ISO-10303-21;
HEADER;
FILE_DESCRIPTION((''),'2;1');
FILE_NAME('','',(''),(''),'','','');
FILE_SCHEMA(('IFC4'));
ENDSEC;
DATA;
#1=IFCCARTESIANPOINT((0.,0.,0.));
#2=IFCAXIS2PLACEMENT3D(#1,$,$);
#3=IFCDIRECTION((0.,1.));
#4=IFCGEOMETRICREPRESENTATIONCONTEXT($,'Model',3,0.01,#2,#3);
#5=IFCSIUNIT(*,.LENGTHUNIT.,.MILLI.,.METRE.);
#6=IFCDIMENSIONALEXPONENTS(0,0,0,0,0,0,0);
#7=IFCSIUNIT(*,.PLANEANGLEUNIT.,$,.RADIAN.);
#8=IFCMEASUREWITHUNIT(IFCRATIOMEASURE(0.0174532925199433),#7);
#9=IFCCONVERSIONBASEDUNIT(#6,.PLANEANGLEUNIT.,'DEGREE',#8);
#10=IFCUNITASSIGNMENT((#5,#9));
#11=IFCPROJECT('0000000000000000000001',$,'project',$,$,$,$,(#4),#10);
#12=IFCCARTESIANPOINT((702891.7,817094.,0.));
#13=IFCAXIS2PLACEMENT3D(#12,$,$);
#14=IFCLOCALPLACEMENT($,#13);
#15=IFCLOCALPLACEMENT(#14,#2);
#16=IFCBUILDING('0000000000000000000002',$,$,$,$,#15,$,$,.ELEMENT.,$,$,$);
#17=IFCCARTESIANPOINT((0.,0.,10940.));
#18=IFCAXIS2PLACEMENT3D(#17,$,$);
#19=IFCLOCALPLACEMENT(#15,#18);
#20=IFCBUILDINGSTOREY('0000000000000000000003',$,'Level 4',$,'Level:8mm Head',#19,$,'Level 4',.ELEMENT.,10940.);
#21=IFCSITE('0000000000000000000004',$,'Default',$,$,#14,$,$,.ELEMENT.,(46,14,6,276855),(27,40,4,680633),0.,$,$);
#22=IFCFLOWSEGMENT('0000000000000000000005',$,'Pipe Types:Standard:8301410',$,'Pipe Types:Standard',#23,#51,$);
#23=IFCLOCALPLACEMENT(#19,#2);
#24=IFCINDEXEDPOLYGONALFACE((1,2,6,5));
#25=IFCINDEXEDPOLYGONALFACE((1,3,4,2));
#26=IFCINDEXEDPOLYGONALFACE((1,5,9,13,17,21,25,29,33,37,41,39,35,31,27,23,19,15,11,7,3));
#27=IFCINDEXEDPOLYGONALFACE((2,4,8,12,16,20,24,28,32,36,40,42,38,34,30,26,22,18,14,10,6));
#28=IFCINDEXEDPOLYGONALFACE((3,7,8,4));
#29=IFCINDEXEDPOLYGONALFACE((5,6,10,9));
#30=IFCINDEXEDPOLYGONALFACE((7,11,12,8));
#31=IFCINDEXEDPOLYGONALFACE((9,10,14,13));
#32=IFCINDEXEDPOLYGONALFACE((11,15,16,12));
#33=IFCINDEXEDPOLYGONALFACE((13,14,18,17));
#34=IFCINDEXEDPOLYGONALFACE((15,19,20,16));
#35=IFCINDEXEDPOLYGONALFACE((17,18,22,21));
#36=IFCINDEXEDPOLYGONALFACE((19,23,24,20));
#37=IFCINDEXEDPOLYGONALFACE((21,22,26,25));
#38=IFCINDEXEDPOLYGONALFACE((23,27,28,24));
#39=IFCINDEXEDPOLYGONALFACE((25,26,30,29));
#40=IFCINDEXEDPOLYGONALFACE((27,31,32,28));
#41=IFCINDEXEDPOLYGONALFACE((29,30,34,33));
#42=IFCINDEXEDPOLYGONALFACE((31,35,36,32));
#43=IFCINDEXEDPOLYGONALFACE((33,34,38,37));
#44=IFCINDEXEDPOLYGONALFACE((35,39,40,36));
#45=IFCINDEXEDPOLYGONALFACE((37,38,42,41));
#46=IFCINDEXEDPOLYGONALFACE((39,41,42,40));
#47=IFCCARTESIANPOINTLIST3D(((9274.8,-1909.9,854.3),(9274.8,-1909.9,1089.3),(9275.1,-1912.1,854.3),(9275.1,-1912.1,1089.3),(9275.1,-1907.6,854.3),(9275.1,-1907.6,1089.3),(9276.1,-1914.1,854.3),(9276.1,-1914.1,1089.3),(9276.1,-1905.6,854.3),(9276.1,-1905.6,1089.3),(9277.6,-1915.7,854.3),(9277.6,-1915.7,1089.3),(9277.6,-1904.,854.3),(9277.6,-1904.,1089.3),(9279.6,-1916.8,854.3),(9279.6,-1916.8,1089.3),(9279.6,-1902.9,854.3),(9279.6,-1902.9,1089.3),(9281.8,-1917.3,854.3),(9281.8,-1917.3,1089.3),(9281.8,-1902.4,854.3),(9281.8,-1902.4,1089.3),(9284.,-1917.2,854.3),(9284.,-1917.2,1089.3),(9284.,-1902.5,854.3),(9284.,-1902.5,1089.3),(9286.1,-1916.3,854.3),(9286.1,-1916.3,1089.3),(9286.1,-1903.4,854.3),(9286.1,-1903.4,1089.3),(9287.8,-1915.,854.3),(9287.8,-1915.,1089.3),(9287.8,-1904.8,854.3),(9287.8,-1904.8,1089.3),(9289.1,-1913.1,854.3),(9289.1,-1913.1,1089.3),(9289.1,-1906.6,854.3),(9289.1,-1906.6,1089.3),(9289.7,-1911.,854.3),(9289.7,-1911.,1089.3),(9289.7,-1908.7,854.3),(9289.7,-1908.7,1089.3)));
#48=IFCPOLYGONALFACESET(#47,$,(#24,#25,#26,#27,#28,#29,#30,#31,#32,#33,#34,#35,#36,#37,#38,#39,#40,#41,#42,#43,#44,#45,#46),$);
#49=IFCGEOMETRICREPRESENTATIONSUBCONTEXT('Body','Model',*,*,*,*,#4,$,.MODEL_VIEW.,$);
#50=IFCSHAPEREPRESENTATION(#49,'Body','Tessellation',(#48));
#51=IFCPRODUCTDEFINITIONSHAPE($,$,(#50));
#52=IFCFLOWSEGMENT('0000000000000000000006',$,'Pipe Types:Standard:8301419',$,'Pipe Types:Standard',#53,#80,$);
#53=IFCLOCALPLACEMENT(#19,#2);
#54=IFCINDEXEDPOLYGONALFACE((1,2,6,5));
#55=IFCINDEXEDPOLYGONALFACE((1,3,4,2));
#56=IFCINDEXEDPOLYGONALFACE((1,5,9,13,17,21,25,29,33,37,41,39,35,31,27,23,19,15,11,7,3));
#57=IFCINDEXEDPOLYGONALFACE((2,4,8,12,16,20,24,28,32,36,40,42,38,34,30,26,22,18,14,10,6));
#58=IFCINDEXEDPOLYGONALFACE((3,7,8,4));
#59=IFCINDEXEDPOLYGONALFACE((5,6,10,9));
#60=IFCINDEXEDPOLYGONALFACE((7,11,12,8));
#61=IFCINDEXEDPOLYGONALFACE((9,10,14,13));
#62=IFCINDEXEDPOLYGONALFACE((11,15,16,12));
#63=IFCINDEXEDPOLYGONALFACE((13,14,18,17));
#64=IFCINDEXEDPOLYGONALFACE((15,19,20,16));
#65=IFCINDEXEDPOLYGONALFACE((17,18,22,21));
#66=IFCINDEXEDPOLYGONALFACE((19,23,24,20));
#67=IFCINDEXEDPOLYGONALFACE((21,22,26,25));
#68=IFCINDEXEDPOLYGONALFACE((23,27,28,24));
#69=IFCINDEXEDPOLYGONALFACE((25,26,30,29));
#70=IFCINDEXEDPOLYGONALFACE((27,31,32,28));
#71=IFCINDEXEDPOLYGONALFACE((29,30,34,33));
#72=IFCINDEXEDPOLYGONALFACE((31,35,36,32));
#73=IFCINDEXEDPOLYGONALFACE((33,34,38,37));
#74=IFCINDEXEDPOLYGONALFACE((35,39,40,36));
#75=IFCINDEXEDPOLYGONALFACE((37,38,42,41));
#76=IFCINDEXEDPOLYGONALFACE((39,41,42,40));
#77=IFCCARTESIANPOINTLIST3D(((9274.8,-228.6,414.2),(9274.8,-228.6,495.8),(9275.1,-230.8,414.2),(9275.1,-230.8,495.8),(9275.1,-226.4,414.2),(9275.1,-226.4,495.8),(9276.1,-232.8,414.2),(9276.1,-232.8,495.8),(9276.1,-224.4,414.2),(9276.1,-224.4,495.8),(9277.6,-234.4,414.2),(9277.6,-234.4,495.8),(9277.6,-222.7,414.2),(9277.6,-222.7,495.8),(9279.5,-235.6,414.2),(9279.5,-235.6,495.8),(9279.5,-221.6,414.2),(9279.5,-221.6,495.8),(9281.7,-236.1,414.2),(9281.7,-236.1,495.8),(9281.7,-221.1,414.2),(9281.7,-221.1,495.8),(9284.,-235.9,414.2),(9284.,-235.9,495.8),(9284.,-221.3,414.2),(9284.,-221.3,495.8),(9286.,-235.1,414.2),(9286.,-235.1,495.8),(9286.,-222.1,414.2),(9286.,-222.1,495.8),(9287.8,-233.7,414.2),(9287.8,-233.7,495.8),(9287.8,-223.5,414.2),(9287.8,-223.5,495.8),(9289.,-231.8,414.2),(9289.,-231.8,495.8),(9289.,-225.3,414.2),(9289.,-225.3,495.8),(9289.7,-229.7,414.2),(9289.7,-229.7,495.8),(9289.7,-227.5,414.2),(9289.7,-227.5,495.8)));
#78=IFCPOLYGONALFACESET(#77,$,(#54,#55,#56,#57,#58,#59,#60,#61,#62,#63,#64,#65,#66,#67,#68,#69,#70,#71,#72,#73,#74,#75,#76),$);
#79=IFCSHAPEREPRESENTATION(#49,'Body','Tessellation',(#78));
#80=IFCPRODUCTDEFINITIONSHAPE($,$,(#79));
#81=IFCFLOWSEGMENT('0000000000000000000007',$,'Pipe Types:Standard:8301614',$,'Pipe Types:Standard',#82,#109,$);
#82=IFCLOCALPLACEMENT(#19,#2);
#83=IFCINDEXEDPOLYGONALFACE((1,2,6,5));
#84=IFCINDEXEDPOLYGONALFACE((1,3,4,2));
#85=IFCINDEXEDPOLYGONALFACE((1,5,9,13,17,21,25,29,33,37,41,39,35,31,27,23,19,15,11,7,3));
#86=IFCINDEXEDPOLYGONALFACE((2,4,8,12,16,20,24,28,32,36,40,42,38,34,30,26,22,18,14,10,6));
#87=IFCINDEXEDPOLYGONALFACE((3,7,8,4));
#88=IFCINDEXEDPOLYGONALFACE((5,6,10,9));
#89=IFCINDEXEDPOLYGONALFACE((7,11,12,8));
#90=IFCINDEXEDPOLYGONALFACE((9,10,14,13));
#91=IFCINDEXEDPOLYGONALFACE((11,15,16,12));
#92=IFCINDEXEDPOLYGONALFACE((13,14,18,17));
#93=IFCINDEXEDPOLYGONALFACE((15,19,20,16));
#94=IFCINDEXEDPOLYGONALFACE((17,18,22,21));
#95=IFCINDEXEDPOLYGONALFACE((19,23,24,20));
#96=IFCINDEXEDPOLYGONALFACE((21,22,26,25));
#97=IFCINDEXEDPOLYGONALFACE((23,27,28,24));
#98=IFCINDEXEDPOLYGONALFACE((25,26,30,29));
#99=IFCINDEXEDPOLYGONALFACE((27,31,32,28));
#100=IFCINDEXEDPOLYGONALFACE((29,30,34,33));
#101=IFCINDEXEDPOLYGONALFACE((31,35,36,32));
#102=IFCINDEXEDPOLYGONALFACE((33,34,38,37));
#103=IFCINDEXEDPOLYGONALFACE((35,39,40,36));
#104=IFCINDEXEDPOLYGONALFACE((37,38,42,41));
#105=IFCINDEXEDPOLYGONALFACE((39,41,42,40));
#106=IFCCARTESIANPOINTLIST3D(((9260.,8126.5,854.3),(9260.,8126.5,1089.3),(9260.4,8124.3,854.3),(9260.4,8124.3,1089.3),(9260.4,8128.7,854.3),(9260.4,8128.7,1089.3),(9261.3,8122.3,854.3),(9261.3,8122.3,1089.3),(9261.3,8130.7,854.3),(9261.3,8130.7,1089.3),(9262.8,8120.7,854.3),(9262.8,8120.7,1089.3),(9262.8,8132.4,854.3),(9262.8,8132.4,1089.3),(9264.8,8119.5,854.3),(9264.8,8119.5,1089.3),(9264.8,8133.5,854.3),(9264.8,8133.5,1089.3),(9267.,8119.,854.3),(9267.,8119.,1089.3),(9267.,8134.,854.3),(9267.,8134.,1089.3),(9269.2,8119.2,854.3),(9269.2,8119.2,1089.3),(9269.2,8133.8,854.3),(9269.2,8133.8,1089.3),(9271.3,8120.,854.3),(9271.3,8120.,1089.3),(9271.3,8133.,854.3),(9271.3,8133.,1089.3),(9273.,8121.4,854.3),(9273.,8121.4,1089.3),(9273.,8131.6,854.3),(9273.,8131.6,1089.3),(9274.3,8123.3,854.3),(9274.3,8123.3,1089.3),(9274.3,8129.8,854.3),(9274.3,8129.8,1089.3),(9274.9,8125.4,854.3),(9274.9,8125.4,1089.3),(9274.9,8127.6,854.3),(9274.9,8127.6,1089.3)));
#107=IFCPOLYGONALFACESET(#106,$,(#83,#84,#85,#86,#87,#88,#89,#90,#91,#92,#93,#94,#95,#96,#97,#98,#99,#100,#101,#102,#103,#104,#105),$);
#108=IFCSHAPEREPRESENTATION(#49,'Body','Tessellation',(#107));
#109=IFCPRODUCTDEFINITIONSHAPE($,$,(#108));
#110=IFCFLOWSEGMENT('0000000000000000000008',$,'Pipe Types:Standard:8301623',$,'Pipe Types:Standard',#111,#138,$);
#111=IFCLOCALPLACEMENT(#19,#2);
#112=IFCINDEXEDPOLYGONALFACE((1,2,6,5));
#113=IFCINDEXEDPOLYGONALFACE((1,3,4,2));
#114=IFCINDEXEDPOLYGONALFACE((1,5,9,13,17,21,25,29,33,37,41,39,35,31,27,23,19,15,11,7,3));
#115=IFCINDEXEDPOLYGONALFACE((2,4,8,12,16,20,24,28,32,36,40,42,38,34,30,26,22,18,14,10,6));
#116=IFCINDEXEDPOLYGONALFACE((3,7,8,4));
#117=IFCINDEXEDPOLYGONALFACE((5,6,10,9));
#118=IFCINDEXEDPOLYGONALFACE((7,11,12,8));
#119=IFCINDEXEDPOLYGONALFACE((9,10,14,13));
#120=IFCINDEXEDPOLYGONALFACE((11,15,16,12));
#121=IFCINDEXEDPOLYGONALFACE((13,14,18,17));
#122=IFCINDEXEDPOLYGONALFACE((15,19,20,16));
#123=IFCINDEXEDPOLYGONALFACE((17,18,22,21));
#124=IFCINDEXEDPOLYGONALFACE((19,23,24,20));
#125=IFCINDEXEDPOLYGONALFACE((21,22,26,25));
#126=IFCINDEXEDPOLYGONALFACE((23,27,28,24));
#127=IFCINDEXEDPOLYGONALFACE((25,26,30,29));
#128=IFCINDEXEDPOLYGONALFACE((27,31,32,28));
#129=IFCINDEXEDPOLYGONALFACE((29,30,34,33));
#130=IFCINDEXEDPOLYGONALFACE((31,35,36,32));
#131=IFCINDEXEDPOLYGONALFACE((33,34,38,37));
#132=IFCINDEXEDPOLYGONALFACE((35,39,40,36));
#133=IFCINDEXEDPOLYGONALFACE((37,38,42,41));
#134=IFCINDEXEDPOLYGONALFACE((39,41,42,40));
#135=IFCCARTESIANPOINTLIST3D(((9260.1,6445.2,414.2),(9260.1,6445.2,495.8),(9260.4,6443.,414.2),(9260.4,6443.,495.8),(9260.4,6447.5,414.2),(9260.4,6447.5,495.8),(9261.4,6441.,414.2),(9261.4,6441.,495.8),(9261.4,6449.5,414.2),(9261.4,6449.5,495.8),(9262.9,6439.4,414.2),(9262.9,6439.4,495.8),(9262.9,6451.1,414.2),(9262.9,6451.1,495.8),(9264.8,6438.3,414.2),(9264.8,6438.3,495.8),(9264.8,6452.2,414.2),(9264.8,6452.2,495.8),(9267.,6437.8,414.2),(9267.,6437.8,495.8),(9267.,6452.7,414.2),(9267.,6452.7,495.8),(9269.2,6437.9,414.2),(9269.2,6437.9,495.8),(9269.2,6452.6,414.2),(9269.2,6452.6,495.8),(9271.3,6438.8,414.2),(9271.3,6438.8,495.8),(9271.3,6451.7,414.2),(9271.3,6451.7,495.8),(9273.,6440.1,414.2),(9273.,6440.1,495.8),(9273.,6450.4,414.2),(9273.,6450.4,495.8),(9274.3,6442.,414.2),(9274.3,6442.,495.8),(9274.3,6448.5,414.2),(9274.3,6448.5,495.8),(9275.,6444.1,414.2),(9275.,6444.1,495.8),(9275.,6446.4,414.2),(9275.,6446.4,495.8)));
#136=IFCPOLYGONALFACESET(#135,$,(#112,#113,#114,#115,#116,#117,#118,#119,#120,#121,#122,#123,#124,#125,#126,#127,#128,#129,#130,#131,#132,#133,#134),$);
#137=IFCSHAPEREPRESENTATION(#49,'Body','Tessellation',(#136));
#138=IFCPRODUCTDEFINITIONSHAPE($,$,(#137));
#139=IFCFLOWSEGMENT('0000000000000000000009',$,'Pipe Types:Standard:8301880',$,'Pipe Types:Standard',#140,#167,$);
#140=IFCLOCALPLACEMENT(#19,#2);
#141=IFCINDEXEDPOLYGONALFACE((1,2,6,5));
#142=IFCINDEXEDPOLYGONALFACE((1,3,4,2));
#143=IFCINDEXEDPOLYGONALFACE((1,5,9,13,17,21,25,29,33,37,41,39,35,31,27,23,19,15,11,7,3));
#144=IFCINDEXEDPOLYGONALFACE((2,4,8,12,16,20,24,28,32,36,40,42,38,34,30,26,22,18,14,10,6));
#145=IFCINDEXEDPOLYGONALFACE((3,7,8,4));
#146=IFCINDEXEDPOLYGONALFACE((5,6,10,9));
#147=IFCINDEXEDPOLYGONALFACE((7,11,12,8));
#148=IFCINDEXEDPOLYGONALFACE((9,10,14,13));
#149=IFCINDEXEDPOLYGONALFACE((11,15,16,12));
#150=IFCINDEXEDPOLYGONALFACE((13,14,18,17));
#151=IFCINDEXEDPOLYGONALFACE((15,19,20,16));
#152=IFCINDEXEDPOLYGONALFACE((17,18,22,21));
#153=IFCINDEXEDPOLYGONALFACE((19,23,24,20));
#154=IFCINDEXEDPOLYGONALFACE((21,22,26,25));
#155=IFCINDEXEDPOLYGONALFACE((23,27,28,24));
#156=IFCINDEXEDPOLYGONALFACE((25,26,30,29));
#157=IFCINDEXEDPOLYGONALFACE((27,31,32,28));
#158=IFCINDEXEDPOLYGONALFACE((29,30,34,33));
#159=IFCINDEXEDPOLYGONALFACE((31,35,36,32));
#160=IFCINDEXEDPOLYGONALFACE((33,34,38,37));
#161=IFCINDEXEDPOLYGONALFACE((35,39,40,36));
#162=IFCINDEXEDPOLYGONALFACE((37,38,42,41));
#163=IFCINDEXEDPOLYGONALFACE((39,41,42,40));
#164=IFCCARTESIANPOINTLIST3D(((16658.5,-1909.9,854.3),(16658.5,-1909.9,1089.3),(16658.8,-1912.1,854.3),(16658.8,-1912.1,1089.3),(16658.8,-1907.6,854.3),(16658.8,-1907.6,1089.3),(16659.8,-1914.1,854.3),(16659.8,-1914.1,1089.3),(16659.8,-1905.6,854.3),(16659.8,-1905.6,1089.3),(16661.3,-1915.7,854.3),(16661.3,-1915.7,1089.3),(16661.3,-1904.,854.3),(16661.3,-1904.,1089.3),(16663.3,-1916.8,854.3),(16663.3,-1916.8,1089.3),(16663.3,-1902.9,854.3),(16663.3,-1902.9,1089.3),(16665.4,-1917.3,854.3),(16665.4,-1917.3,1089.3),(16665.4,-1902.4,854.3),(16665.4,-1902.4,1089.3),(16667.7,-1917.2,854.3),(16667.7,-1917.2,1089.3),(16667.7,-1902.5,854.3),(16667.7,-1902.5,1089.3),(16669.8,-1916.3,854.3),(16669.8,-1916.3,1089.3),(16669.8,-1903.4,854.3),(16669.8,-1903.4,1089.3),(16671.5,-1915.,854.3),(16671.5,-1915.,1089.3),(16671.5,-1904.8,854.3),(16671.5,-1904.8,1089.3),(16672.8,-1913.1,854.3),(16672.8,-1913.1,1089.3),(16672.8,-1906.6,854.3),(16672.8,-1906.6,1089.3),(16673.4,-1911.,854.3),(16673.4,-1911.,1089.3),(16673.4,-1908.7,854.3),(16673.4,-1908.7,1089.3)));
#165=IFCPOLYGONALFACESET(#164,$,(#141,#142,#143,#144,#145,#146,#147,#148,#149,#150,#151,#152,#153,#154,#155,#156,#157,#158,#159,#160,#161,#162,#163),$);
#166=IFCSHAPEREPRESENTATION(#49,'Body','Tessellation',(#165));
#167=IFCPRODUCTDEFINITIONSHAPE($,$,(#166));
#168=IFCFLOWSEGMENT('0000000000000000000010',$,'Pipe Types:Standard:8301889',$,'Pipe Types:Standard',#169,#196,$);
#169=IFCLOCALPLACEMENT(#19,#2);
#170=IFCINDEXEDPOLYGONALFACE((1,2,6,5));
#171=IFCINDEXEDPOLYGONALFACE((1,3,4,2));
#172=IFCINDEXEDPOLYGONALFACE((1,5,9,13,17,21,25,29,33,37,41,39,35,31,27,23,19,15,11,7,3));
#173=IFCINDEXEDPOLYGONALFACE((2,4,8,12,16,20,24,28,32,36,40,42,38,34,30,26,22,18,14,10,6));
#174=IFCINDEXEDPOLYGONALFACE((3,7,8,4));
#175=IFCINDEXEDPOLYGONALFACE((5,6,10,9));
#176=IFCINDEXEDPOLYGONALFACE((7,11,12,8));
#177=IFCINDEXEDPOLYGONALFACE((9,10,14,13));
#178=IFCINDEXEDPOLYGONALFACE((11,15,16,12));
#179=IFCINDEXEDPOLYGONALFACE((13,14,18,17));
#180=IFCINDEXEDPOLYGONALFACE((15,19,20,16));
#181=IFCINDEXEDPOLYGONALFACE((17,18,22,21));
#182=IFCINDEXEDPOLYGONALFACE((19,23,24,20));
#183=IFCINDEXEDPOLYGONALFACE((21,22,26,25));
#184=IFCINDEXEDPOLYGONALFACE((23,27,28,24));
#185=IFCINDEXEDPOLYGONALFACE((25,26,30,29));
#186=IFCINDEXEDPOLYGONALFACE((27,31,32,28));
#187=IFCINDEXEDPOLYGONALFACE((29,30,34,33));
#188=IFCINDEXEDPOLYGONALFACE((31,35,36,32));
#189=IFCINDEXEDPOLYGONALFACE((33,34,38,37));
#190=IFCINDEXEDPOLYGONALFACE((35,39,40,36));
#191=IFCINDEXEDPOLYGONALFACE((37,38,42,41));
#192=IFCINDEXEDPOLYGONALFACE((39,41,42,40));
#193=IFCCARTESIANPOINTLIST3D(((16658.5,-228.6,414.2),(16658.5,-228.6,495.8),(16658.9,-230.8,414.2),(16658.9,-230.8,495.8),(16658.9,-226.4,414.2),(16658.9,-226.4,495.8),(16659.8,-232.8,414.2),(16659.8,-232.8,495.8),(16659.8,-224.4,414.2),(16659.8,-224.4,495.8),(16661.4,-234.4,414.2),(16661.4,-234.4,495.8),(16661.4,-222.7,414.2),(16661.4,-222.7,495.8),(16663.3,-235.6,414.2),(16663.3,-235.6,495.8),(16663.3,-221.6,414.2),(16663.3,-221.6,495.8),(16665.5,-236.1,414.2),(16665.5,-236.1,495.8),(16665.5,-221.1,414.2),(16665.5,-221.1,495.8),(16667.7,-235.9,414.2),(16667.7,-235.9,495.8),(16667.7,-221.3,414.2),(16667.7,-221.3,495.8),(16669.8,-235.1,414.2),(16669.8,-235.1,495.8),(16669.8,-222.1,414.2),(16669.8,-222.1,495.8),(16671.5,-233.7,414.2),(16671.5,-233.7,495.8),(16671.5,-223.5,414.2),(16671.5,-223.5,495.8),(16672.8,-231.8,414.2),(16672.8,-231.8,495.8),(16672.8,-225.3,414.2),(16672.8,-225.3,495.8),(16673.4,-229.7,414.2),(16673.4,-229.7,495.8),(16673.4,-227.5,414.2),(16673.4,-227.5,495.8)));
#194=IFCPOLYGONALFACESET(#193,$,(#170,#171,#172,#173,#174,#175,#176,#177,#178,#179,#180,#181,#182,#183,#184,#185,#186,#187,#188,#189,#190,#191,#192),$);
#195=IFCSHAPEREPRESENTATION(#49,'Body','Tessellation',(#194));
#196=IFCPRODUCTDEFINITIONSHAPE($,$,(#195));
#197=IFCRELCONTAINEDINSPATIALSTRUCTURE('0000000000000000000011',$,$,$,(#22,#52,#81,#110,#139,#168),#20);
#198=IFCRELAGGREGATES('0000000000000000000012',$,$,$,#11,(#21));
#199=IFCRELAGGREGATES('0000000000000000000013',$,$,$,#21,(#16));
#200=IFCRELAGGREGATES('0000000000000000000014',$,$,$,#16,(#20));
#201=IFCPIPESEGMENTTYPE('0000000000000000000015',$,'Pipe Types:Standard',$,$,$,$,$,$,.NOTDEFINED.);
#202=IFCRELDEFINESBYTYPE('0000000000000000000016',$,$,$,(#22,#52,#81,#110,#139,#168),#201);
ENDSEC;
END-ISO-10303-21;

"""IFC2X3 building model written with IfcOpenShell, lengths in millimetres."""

from ifc_helpers import new_model, entity, si_unit, converted_unit, direction, frame, origin, origin_2d_with_axis, place, context, subcontext, project, spatial, circle, extrude, type_object, element, save


model = new_model("IFC2X3")

# Units and contexts
model_context = context("Model", 3, precision=0.01, world=origin(), true_north=direction((0.0, 1.0)))
body_context = subcontext(model_context, "Body", "Model", "MODEL_VIEW")
ifc_project = project(units=[si_unit("LENGTHUNIT", "METRE", prefix="MILLI"), converted_unit("PLANEANGLEUNIT", "DEGREE", entity("IfcRatioMeasure", 0.0174532925199433), si_unit("PLANEANGLEUNIT", "RADIAN"), dimensions=[0, 0, 0, 0, 0, 0, 0])], contexts=[model_context])

# Site, building, storey
site_placement = place(None, frame((702891.7, 817094.0, 0.0)))
site = spatial("IfcSite", under=ifc_project, at=site_placement, Name="Default", CompositionType="ELEMENT", RefLatitude=(46, 14, 6, 276855), RefLongitude=(27, 40, 4, 680633), RefElevation=0.0)
building_placement = place(site_placement, origin())
building = spatial("IfcBuilding", under=site, at=building_placement, CompositionType="ELEMENT")
storey_placement = place(building_placement, frame((0.0, 0.0, 10940.0)))
storey = spatial("IfcBuildingStorey", under=building, at=storey_placement, Name="Level 4", ObjectType="Level:8mm Head", LongName="Level 4", CompositionType="ELEMENT", Elevation=10940.0)

# Flow segments
pipe_segment_type = type_object("IfcPipeSegmentType", Name="Pipe Types:Standard", PredefinedType="NOTDEFINED")
flow_segment_1_placement = place(storey_placement, origin())
element("IfcFlowSegment", 1, at=flow_segment_1_placement, inside=storey, type_object=pipe_segment_type, Name="Pipe Types:Standard:8301410", ObjectType="Pipe Types:Standard", context=body_context, shape_type="SweptSolid", body=[
    extrude(circle(Radius=7.5, at=origin_2d_with_axis()), frame((9282.3, -1909.9, 854.3), z_axis=(0.0, 0.0, 1.0), x_axis=(-1.0, 0.0, 0.0)), (0.0, 0.0, 1.0), 235.0),
])
flow_segment_2_placement = place(storey_placement, origin())
element("IfcFlowSegment", 2, at=flow_segment_2_placement, inside=storey, type_object=pipe_segment_type, Name="Pipe Types:Standard:8301419", ObjectType="Pipe Types:Standard", context=body_context, shape_type="SweptSolid", body=[
    extrude(circle(Radius=7.5, at=origin_2d_with_axis()), frame((9282.3, -228.6, 414.2), z_axis=(0.0, 0.0, 1.0), x_axis=(-1.0, 0.0, 0.0)), (0.0, 0.0, 1.0), 81.6),
])
flow_segment_3_placement = place(storey_placement, origin())
element("IfcFlowSegment", 3, at=flow_segment_3_placement, inside=storey, type_object=pipe_segment_type, Name="Pipe Types:Standard:8301614", ObjectType="Pipe Types:Standard", context=body_context, shape_type="SweptSolid", body=[
    extrude(circle(Radius=7.5, at=origin_2d_with_axis()), frame((9267.5, 8126.5, 854.3), z_axis=(0.0, 0.0, 1.0), x_axis=(-1.0, 0.0, 0.0)), (0.0, 0.0, 1.0), 235.0),
])
flow_segment_4_placement = place(storey_placement, origin())
element("IfcFlowSegment", 4, at=flow_segment_4_placement, inside=storey, type_object=pipe_segment_type, Name="Pipe Types:Standard:8301623", ObjectType="Pipe Types:Standard", context=body_context, shape_type="SweptSolid", body=[
    extrude(circle(Radius=7.5, at=origin_2d_with_axis()), frame((9267.6, 6445.2, 414.2), z_axis=(0.0, 0.0, 1.0), x_axis=(-1.0, 0.0, 0.0)), (0.0, 0.0, 1.0), 81.6),
])
flow_segment_5_placement = place(storey_placement, origin())
element("IfcFlowSegment", 5, at=flow_segment_5_placement, inside=storey, type_object=pipe_segment_type, Name="Pipe Types:Standard:8301880", ObjectType="Pipe Types:Standard", context=body_context, shape_type="SweptSolid", body=[
    extrude(circle(Radius=7.5, at=origin_2d_with_axis()), frame((16666.0, -1909.9, 854.3), z_axis=(0.0, 0.0, 1.0), x_axis=(-1.0, 0.0, 0.0)), (0.0, 0.0, 1.0), 235.0),
])
flow_segment_6_placement = place(storey_placement, origin())
element("IfcFlowSegment", 6, at=flow_segment_6_placement, inside=storey, type_object=pipe_segment_type, Name="Pipe Types:Standard:8301889", ObjectType="Pipe Types:Standard", context=body_context, shape_type="SweptSolid", body=[
    extrude(circle(Radius=7.5, at=origin_2d_with_axis()), frame((16666.0, -228.6, 414.2), z_axis=(0.0, 0.0, 1.0), x_axis=(-1.0, 0.0, 0.0)), (0.0, 0.0, 1.0), 81.6),
])

save(model, "model.ifc")
